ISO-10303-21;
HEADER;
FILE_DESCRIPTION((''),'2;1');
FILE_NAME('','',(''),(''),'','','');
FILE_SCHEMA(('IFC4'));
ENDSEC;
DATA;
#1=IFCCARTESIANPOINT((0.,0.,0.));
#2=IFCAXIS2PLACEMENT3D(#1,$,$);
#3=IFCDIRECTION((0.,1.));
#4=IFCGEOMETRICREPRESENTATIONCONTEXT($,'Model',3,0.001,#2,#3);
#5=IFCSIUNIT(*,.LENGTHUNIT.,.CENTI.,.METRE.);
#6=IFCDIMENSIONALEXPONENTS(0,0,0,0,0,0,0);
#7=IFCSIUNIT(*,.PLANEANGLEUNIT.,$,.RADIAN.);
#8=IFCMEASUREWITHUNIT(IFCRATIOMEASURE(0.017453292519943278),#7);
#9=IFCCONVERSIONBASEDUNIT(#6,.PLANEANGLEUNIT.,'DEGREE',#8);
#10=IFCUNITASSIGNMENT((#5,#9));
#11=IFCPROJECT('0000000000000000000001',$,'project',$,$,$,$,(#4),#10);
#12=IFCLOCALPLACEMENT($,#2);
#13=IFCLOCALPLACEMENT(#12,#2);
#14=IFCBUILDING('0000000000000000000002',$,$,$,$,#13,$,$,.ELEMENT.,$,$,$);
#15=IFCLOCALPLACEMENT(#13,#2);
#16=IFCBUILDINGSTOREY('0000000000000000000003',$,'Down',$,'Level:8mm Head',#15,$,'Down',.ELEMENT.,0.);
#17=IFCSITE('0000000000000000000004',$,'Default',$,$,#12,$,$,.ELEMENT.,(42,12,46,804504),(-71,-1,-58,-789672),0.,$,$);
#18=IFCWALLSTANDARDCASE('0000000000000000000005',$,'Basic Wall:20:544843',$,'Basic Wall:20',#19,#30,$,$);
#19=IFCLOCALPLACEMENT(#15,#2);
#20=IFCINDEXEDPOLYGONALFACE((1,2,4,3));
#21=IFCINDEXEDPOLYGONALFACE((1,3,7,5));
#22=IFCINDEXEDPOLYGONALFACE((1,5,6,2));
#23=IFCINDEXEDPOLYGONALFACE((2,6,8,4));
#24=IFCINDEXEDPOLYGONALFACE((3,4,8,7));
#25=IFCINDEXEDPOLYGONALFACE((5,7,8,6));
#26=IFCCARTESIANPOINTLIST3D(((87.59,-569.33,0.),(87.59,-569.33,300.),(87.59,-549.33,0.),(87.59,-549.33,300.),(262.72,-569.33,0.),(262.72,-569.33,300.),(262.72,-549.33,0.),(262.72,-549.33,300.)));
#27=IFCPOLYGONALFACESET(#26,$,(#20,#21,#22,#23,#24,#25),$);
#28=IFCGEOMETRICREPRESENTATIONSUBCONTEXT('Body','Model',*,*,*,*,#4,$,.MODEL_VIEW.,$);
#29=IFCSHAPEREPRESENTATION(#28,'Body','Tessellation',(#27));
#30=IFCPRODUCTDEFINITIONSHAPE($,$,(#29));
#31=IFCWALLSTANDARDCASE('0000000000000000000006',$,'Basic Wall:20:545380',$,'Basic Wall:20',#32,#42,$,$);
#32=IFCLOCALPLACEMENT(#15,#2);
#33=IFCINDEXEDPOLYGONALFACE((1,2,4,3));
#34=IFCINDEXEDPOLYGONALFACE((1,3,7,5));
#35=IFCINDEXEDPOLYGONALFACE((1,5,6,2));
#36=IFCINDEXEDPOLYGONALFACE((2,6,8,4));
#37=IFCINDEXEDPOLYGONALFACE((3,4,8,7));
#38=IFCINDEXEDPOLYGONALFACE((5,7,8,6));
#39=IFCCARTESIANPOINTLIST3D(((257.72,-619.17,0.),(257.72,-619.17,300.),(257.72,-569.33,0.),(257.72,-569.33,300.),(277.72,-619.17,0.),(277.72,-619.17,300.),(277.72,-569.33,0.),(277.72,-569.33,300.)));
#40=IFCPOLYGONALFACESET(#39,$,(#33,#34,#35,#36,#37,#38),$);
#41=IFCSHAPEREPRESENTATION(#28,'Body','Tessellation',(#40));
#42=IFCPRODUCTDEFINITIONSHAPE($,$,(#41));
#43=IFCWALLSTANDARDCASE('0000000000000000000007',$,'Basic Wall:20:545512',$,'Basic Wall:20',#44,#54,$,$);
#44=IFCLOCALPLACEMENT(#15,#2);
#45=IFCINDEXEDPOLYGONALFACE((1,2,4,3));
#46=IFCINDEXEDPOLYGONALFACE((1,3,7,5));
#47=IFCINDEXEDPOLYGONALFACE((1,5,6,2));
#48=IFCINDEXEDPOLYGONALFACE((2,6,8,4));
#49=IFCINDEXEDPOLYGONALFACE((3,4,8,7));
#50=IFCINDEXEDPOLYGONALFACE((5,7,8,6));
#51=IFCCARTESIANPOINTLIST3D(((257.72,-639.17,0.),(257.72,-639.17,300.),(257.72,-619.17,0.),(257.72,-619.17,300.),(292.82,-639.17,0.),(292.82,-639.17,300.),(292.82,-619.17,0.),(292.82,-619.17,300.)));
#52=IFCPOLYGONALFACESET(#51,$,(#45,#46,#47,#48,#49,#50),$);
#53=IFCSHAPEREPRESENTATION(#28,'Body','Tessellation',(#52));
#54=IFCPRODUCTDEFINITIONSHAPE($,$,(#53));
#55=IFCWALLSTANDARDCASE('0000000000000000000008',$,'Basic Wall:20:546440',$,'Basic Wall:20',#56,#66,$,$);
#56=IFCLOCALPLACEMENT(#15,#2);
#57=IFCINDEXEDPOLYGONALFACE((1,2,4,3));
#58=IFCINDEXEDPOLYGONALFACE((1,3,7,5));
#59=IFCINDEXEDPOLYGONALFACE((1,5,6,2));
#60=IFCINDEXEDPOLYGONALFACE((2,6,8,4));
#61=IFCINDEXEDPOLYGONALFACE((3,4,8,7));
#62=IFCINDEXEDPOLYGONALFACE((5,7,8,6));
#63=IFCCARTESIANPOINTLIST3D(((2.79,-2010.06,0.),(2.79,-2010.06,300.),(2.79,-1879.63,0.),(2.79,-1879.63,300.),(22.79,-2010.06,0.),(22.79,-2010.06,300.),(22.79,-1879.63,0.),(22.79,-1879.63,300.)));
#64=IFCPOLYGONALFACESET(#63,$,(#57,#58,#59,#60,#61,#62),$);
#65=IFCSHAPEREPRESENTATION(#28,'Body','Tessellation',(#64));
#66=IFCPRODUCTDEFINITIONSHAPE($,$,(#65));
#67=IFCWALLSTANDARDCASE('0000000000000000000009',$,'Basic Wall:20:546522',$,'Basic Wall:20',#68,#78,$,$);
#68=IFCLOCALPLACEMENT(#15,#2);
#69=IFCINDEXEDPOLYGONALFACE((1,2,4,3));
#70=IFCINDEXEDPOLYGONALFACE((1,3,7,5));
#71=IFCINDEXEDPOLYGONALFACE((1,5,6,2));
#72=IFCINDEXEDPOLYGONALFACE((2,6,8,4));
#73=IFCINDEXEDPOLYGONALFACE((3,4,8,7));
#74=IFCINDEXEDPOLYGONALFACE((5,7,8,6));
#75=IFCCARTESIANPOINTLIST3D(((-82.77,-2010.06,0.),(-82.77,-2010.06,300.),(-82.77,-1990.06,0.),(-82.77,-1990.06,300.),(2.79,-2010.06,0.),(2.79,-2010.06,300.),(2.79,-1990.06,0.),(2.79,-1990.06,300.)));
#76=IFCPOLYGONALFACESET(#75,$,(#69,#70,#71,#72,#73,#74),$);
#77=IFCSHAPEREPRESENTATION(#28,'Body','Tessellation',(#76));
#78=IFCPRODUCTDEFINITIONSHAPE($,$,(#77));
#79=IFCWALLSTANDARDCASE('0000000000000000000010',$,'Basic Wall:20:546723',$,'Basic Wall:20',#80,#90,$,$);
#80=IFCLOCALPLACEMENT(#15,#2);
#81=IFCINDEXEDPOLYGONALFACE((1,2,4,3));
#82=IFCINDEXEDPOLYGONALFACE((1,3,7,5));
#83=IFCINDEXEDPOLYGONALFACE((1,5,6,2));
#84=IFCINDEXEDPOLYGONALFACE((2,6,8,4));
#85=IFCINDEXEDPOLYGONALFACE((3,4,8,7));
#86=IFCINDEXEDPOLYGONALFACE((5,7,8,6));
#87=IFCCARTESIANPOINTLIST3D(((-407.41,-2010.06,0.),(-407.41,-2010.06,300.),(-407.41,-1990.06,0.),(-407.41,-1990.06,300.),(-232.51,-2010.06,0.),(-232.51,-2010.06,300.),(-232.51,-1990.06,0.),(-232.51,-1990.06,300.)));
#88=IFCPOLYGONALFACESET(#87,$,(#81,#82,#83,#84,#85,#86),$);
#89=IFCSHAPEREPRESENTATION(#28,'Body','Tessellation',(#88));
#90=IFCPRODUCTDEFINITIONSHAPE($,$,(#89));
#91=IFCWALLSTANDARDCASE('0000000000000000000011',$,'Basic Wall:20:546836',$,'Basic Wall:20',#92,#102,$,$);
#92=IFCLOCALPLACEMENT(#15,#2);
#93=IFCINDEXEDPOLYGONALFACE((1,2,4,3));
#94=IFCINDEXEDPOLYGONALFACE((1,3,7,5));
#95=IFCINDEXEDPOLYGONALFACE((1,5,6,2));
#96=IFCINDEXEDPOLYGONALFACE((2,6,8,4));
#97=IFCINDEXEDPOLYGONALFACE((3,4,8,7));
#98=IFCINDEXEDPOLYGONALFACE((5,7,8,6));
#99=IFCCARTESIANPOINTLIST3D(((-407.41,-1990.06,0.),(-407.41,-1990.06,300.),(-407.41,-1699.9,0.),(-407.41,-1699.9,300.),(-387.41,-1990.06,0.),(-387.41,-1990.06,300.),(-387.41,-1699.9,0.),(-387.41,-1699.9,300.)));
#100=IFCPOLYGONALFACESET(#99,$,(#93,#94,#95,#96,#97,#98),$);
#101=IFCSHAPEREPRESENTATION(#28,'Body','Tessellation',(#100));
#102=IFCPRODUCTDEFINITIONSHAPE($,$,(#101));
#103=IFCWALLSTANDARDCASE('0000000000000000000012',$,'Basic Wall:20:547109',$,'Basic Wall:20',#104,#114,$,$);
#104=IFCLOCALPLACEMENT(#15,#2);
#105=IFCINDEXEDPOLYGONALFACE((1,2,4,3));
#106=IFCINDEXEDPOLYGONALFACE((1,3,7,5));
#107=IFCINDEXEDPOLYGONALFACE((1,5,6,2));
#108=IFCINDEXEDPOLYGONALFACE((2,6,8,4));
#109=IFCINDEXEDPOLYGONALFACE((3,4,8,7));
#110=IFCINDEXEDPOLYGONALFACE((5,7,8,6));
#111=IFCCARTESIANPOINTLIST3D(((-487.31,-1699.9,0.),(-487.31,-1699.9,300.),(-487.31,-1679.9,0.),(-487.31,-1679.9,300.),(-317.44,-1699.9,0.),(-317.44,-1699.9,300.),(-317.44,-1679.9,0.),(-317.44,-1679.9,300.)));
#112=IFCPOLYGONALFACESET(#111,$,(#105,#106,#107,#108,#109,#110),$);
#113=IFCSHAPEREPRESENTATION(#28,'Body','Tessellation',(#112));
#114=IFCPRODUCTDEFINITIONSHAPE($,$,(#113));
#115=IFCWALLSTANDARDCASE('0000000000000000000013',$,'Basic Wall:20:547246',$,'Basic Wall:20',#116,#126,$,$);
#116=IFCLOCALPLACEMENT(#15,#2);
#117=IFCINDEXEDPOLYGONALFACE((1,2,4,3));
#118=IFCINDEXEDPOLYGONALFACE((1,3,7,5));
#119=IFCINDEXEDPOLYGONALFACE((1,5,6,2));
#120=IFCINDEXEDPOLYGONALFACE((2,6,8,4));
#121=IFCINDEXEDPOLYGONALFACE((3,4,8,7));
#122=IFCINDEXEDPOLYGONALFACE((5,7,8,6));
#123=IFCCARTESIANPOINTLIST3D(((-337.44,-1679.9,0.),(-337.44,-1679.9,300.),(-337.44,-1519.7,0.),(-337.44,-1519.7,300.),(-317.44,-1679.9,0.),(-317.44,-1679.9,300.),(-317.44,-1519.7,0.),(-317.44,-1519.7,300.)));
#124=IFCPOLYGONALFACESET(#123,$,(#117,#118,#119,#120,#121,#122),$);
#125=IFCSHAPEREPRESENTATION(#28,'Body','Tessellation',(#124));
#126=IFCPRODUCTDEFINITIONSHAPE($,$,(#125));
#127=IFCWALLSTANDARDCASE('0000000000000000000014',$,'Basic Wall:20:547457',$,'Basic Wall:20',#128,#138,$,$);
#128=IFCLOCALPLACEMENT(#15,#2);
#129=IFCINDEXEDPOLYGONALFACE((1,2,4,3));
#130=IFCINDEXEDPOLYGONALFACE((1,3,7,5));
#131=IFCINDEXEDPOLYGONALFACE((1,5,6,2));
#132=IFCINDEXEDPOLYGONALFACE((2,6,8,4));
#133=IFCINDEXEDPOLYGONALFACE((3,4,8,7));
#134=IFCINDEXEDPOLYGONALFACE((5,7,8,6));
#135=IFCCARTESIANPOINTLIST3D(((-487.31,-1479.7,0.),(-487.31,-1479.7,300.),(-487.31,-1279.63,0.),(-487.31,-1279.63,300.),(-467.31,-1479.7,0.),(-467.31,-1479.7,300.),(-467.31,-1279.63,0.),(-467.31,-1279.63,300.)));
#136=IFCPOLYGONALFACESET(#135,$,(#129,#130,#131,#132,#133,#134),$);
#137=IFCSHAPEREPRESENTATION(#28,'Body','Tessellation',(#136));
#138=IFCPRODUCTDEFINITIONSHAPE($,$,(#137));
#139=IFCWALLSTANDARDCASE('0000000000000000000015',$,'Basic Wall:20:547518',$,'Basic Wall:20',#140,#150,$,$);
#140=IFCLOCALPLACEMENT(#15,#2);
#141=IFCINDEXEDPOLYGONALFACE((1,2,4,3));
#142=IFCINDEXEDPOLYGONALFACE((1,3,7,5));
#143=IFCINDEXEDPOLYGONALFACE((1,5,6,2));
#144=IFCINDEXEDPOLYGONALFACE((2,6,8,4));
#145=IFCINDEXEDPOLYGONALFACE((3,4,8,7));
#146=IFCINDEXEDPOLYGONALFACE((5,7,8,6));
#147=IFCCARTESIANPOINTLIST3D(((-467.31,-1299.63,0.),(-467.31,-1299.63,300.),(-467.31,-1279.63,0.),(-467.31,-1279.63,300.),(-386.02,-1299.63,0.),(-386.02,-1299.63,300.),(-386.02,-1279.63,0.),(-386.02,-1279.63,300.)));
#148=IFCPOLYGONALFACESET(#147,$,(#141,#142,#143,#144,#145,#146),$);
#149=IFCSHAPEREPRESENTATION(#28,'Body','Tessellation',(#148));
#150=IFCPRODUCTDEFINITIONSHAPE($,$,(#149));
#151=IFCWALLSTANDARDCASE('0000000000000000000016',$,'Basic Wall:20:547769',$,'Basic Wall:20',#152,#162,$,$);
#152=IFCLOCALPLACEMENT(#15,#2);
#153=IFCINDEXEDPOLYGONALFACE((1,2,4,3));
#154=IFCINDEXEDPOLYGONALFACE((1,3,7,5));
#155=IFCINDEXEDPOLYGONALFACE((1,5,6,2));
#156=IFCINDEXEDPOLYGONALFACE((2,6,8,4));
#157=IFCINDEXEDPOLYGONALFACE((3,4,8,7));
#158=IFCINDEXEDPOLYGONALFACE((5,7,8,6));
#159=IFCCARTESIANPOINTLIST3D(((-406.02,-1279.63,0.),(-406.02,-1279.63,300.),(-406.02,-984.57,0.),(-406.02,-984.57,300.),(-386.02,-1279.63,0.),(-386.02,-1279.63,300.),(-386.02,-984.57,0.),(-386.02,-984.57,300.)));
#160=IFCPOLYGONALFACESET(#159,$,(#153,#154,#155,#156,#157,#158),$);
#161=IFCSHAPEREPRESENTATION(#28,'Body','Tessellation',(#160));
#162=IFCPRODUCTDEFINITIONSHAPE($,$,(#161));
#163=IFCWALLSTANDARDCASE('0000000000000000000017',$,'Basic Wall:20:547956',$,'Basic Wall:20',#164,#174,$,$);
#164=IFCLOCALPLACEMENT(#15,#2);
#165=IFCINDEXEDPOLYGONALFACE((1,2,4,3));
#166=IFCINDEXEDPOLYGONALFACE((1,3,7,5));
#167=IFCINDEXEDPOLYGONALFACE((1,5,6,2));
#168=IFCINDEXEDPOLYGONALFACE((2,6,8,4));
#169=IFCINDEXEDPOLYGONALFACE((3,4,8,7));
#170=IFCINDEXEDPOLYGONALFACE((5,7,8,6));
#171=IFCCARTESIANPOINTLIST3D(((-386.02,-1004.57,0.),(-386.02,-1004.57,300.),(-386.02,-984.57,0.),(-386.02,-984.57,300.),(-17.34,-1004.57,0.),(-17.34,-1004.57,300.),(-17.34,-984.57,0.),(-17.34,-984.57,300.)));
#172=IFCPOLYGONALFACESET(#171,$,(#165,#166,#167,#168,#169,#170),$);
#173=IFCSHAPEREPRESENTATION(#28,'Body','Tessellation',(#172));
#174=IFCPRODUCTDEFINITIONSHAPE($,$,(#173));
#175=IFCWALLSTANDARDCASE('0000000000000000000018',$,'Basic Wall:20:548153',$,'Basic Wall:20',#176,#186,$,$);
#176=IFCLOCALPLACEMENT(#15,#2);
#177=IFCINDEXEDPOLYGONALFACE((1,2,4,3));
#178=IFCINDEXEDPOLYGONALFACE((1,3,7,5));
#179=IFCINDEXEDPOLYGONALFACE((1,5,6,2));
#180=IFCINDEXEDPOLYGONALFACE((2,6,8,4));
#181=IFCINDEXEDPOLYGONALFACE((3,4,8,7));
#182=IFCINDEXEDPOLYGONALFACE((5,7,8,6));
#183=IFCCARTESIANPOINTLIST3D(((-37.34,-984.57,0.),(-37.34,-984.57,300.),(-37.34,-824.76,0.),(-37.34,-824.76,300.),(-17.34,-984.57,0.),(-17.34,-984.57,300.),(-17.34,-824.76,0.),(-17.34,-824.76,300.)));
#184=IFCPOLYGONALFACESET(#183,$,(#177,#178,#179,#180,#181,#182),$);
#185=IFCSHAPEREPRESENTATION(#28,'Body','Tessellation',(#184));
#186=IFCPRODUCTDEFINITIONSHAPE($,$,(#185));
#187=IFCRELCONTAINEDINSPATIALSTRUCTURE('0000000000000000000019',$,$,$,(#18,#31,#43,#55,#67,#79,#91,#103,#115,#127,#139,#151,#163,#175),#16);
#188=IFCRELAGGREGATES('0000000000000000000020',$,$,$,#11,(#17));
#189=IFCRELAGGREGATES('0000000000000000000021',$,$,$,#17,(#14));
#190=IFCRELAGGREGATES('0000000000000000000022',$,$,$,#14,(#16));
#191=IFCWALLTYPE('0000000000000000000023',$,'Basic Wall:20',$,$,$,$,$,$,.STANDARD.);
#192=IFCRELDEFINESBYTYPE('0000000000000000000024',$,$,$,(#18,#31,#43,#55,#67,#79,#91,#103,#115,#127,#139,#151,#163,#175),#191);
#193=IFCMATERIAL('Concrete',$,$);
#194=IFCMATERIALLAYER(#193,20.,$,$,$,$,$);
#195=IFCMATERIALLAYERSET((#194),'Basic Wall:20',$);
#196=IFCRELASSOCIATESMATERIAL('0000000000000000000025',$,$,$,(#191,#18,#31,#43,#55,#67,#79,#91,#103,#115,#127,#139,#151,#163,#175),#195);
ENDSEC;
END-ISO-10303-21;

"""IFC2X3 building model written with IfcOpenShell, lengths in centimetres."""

from ifc_helpers import new_model, entity, si_unit, converted_unit, direction, frame, frame_2d, origin, place, context, subcontext, project, spatial, rectangle, extrude, material, layer, layer_set, layer_usage, type_object, element, save


model = new_model("IFC2X3")

# Units and contexts
model_context = context("Model", 3, precision=0.001, world=origin(), true_north=direction((0.0, 1.0)))
body_context = subcontext(model_context, "Body", "Model", "MODEL_VIEW")
ifc_project = project(units=[si_unit("LENGTHUNIT", "METRE", prefix="CENTI"), converted_unit("PLANEANGLEUNIT", "DEGREE", entity("IfcRatioMeasure", 0.017453292519943278), si_unit("PLANEANGLEUNIT", "RADIAN"), dimensions=[0, 0, 0, 0, 0, 0, 0])], contexts=[model_context])

# Site, building, storey
site_placement = place(None, origin())
site = spatial("IfcSite", under=ifc_project, at=site_placement, Name="Default", CompositionType="ELEMENT", RefLatitude=(42, 12, 46, 804504), RefLongitude=(-71, -1, -58, -789672), RefElevation=0.0)
building_placement = place(site_placement, origin())
building = spatial("IfcBuilding", under=site, at=building_placement, CompositionType="ELEMENT")
storey_placement = place(building_placement, origin())
storey = spatial("IfcBuildingStorey", under=building, at=storey_placement, Name="Down", ObjectType="Level:8mm Head", LongName="Down", CompositionType="ELEMENT", Elevation=0.0)

# Walls
ifc_material = material(Name="Concrete")
ifc_layer_1 = layer(ifc_material, 20.0)
ifc_layer_set_1 = layer_set([ifc_layer_1], Name="Basic Wall:20")
ifc_layer_usage_1 = layer_usage(ifc_layer_set_1, "AXIS2", "POSITIVE", -10.0)
wall_type_1 = type_object("IfcWallType", Name="Basic Wall:20", PredefinedType="STANDARD", material=ifc_layer_set_1)
wall_1_placement = place(storey_placement, frame((87.59, -559.33, 0.0)))
element("IfcWallStandardCase", 1, at=wall_1_placement, inside=storey, type_object=wall_type_1, material=ifc_layer_usage_1, Name="Basic Wall:20:544843", ObjectType="Basic Wall:20", context=body_context, shape_type="SweptSolid", body=[
    extrude(rectangle(XDim=175.13, YDim=20.0, at=frame_2d((87.57, 0.0), x_axis=(-1.0, 0.0))), origin(), (0.0, 0.0, 1.0), 300.0),
])
ifc_layer_usage_2 = layer_usage(ifc_layer_set_1, "AXIS2", "NEGATIVE", 10.0)
wall_2_placement = place(storey_placement, frame((267.72, -569.33, 0.0), z_axis=(0.0, 0.0, 1.0), x_axis=(0.0, -1.0, 0.0)))
element("IfcWallStandardCase", 2, at=wall_2_placement, inside=storey, type_object=wall_type_1, material=ifc_layer_usage_2, Name="Basic Wall:20:545380", ObjectType="Basic Wall:20", context=body_context, shape_type="SweptSolid", body=[
    extrude(rectangle(XDim=49.83, YDim=20.0, at=frame_2d((24.92, 0.0), x_axis=(-1.0, 0.0))), origin(), (0.0, 0.0, 1.0), 300.0),
])
ifc_layer_usage_3 = layer_usage(ifc_layer_set_1, "AXIS2", "POSITIVE", -10.0)
wall_3_placement = place(storey_placement, frame((257.72, -629.17, 0.0)))
element("IfcWallStandardCase", 3, at=wall_3_placement, inside=storey, type_object=wall_type_1, material=ifc_layer_usage_3, Name="Basic Wall:20:545512", ObjectType="Basic Wall:20", context=body_context, shape_type="SweptSolid", body=[
    extrude(rectangle(XDim=35.1, YDim=20.0, at=frame_2d((17.55, 0.0), x_axis=(-1.0, 0.0))), origin(), (0.0, 0.0, 1.0), 300.0),
])
ifc_layer_usage_4 = layer_usage(ifc_layer_set_1, "AXIS2", "POSITIVE", -10.0)
wall_4_placement = place(storey_placement, frame((12.79, -1879.63, 0.0), z_axis=(0.0, 0.0, 1.0), x_axis=(0.0, -1.0, 0.0)))
element("IfcWallStandardCase", 4, at=wall_4_placement, inside=storey, type_object=wall_type_1, material=ifc_layer_usage_4, Name="Basic Wall:20:546440", ObjectType="Basic Wall:20", context=body_context, shape_type="SweptSolid", body=[
    extrude(rectangle(XDim=130.43, YDim=20.0, at=frame_2d((65.22, 0.0), x_axis=(-1.0, 0.0))), origin(), (0.0, 0.0, 1.0), 300.0),
])
ifc_layer_usage_5 = layer_usage(ifc_layer_set_1, "AXIS2", "NEGATIVE", 10.0)
wall_5_placement = place(storey_placement, frame((2.79, -2000.06, 0.0), z_axis=(0.0, 0.0, 1.0), x_axis=(-1.0, 0.0, 0.0)))
element("IfcWallStandardCase", 5, at=wall_5_placement, inside=storey, type_object=wall_type_1, material=ifc_layer_usage_5, Name="Basic Wall:20:546522", ObjectType="Basic Wall:20", context=body_context, shape_type="SweptSolid", body=[
    extrude(rectangle(XDim=85.56, YDim=20.0, at=frame_2d((42.78, 0.0), x_axis=(-1.0, 0.0))), origin(), (0.0, 0.0, 1.0), 300.0),
])
ifc_layer_usage_6 = layer_usage(ifc_layer_set_1, "AXIS2", "NEGATIVE", 10.0)
wall_6_placement = place(storey_placement, frame((-232.51, -2000.06, 0.0), z_axis=(0.0, 0.0, 1.0), x_axis=(-1.0, 0.0, 0.0)))
element("IfcWallStandardCase", 6, at=wall_6_placement, inside=storey, type_object=wall_type_1, material=ifc_layer_usage_6, Name="Basic Wall:20:546723", ObjectType="Basic Wall:20", context=body_context, shape_type="SweptSolid", body=[
    extrude(rectangle(XDim=174.9, YDim=20.0, at=frame_2d((87.45, 0.0), x_axis=(-1.0, 0.0))), origin(), (0.0, 0.0, 1.0), 300.0),
])
ifc_layer_usage_7 = layer_usage(ifc_layer_set_1, "AXIS2", "NEGATIVE", 10.0)
wall_7_placement = place(storey_placement, frame((-397.41, -1990.06, 0.0), z_axis=(0.0, 0.0, 1.0), x_axis=(0.0, 1.0, 0.0)))
element("IfcWallStandardCase", 7, at=wall_7_placement, inside=storey, type_object=wall_type_1, material=ifc_layer_usage_7, Name="Basic Wall:20:546836", ObjectType="Basic Wall:20", context=body_context, shape_type="SweptSolid", body=[
    extrude(rectangle(XDim=290.17, YDim=20.0, at=frame_2d((145.08, 0.0), x_axis=(-1.0, 0.0))), origin(), (0.0, 0.0, 1.0), 300.0),
])
ifc_layer_usage_8 = layer_usage(ifc_layer_set_1, "AXIS2", "POSITIVE", -10.0)
wall_8_placement = place(storey_placement, frame((-487.31, -1689.9, 0.0)))
element("IfcWallStandardCase", 8, at=wall_8_placement, inside=storey, type_object=wall_type_1, material=ifc_layer_usage_8, Name="Basic Wall:20:547109", ObjectType="Basic Wall:20", context=body_context, shape_type="SweptSolid", body=[
    extrude(rectangle(XDim=169.87, YDim=20.0, at=frame_2d((84.93, 0.0), x_axis=(-1.0, 0.0))), origin(), (0.0, 0.0, 1.0), 300.0),
])
ifc_layer_usage_9 = layer_usage(ifc_layer_set_1, "AXIS2", "POSITIVE", -10.0)
wall_9_placement = place(storey_placement, frame((-327.44, -1679.9, 0.0), z_axis=(0.0, 0.0, 1.0), x_axis=(0.0, 1.0, 0.0)))
element("IfcWallStandardCase", 9, at=wall_9_placement, inside=storey, type_object=wall_type_1, material=ifc_layer_usage_9, Name="Basic Wall:20:547246", ObjectType="Basic Wall:20", context=body_context, shape_type="SweptSolid", body=[
    extrude(rectangle(XDim=160.2, YDim=20.0, at=frame_2d((80.1, 0.0), x_axis=(-1.0, 0.0))), origin(), (0.0, 0.0, 1.0), 300.0),
])
ifc_layer_usage_10 = layer_usage(ifc_layer_set_1, "AXIS2", "NEGATIVE", 10.0)
wall_10_placement = place(storey_placement, frame((-477.31, -1479.7, 0.0), z_axis=(0.0, 0.0, 1.0), x_axis=(0.0, 1.0, 0.0)))
element("IfcWallStandardCase", 10, at=wall_10_placement, inside=storey, type_object=wall_type_1, material=ifc_layer_usage_10, Name="Basic Wall:20:547457", ObjectType="Basic Wall:20", context=body_context, shape_type="SweptSolid", body=[
    extrude(rectangle(XDim=200.07, YDim=20.0, at=frame_2d((100.03, 0.0), x_axis=(-1.0, 0.0))), origin(), (0.0, 0.0, 1.0), 300.0),
])
ifc_layer_usage_11 = layer_usage(ifc_layer_set_1, "AXIS2", "NEGATIVE", 10.0)
wall_11_placement = place(storey_placement, frame((-467.31, -1289.63, 0.0)))
element("IfcWallStandardCase", 11, at=wall_11_placement, inside=storey, type_object=wall_type_1, material=ifc_layer_usage_11, Name="Basic Wall:20:547518", ObjectType="Basic Wall:20", context=body_context, shape_type="SweptSolid", body=[
    extrude(rectangle(XDim=81.29, YDim=20.0, at=frame_2d((40.65, 0.0), x_axis=(-1.0, 0.0))), origin(), (0.0, 0.0, 1.0), 300.0),
])
ifc_layer_usage_12 = layer_usage(ifc_layer_set_1, "AXIS2", "POSITIVE", -10.0)
wall_12_placement = place(storey_placement, frame((-396.02, -1279.63, 0.0), z_axis=(0.0, 0.0, 1.0), x_axis=(0.0, 1.0, 0.0)))
element("IfcWallStandardCase", 12, at=wall_12_placement, inside=storey, type_object=wall_type_1, material=ifc_layer_usage_12, Name="Basic Wall:20:547769", ObjectType="Basic Wall:20", context=body_context, shape_type="SweptSolid", body=[
    extrude(rectangle(XDim=295.07, YDim=20.0, at=frame_2d((147.53, 0.0), x_axis=(-1.0, 0.0))), origin(), (0.0, 0.0, 1.0), 300.0),
])
ifc_layer_usage_13 = layer_usage(ifc_layer_set_1, "AXIS2", "NEGATIVE", 10.0)
wall_13_placement = place(storey_placement, frame((-386.02, -994.57, 0.0)))
element("IfcWallStandardCase", 13, at=wall_13_placement, inside=storey, type_object=wall_type_1, material=ifc_layer_usage_13, Name="Basic Wall:20:547956", ObjectType="Basic Wall:20", context=body_context, shape_type="SweptSolid", body=[
    extrude(rectangle(XDim=368.68, YDim=20.0, at=frame_2d((184.34, 0.0), x_axis=(-1.0, 0.0))), origin(), (0.0, 0.0, 1.0), 300.0),
])
ifc_layer_usage_14 = layer_usage(ifc_layer_set_1, "AXIS2", "POSITIVE", -10.0)
wall_14_placement = place(storey_placement, frame((-27.34, -984.57, 0.0), z_axis=(0.0, 0.0, 1.0), x_axis=(0.0, 1.0, 0.0)))
element("IfcWallStandardCase", 14, at=wall_14_placement, inside=storey, type_object=wall_type_1, material=ifc_layer_usage_14, Name="Basic Wall:20:548153", ObjectType="Basic Wall:20", context=body_context, shape_type="SweptSolid", body=[
    extrude(rectangle(XDim=159.8, YDim=20.0, at=frame_2d((79.9, 0.0), x_axis=(-1.0, 0.0))), origin(), (0.0, 0.0, 1.0), 300.0),
])

save(model, "model.ifc")
